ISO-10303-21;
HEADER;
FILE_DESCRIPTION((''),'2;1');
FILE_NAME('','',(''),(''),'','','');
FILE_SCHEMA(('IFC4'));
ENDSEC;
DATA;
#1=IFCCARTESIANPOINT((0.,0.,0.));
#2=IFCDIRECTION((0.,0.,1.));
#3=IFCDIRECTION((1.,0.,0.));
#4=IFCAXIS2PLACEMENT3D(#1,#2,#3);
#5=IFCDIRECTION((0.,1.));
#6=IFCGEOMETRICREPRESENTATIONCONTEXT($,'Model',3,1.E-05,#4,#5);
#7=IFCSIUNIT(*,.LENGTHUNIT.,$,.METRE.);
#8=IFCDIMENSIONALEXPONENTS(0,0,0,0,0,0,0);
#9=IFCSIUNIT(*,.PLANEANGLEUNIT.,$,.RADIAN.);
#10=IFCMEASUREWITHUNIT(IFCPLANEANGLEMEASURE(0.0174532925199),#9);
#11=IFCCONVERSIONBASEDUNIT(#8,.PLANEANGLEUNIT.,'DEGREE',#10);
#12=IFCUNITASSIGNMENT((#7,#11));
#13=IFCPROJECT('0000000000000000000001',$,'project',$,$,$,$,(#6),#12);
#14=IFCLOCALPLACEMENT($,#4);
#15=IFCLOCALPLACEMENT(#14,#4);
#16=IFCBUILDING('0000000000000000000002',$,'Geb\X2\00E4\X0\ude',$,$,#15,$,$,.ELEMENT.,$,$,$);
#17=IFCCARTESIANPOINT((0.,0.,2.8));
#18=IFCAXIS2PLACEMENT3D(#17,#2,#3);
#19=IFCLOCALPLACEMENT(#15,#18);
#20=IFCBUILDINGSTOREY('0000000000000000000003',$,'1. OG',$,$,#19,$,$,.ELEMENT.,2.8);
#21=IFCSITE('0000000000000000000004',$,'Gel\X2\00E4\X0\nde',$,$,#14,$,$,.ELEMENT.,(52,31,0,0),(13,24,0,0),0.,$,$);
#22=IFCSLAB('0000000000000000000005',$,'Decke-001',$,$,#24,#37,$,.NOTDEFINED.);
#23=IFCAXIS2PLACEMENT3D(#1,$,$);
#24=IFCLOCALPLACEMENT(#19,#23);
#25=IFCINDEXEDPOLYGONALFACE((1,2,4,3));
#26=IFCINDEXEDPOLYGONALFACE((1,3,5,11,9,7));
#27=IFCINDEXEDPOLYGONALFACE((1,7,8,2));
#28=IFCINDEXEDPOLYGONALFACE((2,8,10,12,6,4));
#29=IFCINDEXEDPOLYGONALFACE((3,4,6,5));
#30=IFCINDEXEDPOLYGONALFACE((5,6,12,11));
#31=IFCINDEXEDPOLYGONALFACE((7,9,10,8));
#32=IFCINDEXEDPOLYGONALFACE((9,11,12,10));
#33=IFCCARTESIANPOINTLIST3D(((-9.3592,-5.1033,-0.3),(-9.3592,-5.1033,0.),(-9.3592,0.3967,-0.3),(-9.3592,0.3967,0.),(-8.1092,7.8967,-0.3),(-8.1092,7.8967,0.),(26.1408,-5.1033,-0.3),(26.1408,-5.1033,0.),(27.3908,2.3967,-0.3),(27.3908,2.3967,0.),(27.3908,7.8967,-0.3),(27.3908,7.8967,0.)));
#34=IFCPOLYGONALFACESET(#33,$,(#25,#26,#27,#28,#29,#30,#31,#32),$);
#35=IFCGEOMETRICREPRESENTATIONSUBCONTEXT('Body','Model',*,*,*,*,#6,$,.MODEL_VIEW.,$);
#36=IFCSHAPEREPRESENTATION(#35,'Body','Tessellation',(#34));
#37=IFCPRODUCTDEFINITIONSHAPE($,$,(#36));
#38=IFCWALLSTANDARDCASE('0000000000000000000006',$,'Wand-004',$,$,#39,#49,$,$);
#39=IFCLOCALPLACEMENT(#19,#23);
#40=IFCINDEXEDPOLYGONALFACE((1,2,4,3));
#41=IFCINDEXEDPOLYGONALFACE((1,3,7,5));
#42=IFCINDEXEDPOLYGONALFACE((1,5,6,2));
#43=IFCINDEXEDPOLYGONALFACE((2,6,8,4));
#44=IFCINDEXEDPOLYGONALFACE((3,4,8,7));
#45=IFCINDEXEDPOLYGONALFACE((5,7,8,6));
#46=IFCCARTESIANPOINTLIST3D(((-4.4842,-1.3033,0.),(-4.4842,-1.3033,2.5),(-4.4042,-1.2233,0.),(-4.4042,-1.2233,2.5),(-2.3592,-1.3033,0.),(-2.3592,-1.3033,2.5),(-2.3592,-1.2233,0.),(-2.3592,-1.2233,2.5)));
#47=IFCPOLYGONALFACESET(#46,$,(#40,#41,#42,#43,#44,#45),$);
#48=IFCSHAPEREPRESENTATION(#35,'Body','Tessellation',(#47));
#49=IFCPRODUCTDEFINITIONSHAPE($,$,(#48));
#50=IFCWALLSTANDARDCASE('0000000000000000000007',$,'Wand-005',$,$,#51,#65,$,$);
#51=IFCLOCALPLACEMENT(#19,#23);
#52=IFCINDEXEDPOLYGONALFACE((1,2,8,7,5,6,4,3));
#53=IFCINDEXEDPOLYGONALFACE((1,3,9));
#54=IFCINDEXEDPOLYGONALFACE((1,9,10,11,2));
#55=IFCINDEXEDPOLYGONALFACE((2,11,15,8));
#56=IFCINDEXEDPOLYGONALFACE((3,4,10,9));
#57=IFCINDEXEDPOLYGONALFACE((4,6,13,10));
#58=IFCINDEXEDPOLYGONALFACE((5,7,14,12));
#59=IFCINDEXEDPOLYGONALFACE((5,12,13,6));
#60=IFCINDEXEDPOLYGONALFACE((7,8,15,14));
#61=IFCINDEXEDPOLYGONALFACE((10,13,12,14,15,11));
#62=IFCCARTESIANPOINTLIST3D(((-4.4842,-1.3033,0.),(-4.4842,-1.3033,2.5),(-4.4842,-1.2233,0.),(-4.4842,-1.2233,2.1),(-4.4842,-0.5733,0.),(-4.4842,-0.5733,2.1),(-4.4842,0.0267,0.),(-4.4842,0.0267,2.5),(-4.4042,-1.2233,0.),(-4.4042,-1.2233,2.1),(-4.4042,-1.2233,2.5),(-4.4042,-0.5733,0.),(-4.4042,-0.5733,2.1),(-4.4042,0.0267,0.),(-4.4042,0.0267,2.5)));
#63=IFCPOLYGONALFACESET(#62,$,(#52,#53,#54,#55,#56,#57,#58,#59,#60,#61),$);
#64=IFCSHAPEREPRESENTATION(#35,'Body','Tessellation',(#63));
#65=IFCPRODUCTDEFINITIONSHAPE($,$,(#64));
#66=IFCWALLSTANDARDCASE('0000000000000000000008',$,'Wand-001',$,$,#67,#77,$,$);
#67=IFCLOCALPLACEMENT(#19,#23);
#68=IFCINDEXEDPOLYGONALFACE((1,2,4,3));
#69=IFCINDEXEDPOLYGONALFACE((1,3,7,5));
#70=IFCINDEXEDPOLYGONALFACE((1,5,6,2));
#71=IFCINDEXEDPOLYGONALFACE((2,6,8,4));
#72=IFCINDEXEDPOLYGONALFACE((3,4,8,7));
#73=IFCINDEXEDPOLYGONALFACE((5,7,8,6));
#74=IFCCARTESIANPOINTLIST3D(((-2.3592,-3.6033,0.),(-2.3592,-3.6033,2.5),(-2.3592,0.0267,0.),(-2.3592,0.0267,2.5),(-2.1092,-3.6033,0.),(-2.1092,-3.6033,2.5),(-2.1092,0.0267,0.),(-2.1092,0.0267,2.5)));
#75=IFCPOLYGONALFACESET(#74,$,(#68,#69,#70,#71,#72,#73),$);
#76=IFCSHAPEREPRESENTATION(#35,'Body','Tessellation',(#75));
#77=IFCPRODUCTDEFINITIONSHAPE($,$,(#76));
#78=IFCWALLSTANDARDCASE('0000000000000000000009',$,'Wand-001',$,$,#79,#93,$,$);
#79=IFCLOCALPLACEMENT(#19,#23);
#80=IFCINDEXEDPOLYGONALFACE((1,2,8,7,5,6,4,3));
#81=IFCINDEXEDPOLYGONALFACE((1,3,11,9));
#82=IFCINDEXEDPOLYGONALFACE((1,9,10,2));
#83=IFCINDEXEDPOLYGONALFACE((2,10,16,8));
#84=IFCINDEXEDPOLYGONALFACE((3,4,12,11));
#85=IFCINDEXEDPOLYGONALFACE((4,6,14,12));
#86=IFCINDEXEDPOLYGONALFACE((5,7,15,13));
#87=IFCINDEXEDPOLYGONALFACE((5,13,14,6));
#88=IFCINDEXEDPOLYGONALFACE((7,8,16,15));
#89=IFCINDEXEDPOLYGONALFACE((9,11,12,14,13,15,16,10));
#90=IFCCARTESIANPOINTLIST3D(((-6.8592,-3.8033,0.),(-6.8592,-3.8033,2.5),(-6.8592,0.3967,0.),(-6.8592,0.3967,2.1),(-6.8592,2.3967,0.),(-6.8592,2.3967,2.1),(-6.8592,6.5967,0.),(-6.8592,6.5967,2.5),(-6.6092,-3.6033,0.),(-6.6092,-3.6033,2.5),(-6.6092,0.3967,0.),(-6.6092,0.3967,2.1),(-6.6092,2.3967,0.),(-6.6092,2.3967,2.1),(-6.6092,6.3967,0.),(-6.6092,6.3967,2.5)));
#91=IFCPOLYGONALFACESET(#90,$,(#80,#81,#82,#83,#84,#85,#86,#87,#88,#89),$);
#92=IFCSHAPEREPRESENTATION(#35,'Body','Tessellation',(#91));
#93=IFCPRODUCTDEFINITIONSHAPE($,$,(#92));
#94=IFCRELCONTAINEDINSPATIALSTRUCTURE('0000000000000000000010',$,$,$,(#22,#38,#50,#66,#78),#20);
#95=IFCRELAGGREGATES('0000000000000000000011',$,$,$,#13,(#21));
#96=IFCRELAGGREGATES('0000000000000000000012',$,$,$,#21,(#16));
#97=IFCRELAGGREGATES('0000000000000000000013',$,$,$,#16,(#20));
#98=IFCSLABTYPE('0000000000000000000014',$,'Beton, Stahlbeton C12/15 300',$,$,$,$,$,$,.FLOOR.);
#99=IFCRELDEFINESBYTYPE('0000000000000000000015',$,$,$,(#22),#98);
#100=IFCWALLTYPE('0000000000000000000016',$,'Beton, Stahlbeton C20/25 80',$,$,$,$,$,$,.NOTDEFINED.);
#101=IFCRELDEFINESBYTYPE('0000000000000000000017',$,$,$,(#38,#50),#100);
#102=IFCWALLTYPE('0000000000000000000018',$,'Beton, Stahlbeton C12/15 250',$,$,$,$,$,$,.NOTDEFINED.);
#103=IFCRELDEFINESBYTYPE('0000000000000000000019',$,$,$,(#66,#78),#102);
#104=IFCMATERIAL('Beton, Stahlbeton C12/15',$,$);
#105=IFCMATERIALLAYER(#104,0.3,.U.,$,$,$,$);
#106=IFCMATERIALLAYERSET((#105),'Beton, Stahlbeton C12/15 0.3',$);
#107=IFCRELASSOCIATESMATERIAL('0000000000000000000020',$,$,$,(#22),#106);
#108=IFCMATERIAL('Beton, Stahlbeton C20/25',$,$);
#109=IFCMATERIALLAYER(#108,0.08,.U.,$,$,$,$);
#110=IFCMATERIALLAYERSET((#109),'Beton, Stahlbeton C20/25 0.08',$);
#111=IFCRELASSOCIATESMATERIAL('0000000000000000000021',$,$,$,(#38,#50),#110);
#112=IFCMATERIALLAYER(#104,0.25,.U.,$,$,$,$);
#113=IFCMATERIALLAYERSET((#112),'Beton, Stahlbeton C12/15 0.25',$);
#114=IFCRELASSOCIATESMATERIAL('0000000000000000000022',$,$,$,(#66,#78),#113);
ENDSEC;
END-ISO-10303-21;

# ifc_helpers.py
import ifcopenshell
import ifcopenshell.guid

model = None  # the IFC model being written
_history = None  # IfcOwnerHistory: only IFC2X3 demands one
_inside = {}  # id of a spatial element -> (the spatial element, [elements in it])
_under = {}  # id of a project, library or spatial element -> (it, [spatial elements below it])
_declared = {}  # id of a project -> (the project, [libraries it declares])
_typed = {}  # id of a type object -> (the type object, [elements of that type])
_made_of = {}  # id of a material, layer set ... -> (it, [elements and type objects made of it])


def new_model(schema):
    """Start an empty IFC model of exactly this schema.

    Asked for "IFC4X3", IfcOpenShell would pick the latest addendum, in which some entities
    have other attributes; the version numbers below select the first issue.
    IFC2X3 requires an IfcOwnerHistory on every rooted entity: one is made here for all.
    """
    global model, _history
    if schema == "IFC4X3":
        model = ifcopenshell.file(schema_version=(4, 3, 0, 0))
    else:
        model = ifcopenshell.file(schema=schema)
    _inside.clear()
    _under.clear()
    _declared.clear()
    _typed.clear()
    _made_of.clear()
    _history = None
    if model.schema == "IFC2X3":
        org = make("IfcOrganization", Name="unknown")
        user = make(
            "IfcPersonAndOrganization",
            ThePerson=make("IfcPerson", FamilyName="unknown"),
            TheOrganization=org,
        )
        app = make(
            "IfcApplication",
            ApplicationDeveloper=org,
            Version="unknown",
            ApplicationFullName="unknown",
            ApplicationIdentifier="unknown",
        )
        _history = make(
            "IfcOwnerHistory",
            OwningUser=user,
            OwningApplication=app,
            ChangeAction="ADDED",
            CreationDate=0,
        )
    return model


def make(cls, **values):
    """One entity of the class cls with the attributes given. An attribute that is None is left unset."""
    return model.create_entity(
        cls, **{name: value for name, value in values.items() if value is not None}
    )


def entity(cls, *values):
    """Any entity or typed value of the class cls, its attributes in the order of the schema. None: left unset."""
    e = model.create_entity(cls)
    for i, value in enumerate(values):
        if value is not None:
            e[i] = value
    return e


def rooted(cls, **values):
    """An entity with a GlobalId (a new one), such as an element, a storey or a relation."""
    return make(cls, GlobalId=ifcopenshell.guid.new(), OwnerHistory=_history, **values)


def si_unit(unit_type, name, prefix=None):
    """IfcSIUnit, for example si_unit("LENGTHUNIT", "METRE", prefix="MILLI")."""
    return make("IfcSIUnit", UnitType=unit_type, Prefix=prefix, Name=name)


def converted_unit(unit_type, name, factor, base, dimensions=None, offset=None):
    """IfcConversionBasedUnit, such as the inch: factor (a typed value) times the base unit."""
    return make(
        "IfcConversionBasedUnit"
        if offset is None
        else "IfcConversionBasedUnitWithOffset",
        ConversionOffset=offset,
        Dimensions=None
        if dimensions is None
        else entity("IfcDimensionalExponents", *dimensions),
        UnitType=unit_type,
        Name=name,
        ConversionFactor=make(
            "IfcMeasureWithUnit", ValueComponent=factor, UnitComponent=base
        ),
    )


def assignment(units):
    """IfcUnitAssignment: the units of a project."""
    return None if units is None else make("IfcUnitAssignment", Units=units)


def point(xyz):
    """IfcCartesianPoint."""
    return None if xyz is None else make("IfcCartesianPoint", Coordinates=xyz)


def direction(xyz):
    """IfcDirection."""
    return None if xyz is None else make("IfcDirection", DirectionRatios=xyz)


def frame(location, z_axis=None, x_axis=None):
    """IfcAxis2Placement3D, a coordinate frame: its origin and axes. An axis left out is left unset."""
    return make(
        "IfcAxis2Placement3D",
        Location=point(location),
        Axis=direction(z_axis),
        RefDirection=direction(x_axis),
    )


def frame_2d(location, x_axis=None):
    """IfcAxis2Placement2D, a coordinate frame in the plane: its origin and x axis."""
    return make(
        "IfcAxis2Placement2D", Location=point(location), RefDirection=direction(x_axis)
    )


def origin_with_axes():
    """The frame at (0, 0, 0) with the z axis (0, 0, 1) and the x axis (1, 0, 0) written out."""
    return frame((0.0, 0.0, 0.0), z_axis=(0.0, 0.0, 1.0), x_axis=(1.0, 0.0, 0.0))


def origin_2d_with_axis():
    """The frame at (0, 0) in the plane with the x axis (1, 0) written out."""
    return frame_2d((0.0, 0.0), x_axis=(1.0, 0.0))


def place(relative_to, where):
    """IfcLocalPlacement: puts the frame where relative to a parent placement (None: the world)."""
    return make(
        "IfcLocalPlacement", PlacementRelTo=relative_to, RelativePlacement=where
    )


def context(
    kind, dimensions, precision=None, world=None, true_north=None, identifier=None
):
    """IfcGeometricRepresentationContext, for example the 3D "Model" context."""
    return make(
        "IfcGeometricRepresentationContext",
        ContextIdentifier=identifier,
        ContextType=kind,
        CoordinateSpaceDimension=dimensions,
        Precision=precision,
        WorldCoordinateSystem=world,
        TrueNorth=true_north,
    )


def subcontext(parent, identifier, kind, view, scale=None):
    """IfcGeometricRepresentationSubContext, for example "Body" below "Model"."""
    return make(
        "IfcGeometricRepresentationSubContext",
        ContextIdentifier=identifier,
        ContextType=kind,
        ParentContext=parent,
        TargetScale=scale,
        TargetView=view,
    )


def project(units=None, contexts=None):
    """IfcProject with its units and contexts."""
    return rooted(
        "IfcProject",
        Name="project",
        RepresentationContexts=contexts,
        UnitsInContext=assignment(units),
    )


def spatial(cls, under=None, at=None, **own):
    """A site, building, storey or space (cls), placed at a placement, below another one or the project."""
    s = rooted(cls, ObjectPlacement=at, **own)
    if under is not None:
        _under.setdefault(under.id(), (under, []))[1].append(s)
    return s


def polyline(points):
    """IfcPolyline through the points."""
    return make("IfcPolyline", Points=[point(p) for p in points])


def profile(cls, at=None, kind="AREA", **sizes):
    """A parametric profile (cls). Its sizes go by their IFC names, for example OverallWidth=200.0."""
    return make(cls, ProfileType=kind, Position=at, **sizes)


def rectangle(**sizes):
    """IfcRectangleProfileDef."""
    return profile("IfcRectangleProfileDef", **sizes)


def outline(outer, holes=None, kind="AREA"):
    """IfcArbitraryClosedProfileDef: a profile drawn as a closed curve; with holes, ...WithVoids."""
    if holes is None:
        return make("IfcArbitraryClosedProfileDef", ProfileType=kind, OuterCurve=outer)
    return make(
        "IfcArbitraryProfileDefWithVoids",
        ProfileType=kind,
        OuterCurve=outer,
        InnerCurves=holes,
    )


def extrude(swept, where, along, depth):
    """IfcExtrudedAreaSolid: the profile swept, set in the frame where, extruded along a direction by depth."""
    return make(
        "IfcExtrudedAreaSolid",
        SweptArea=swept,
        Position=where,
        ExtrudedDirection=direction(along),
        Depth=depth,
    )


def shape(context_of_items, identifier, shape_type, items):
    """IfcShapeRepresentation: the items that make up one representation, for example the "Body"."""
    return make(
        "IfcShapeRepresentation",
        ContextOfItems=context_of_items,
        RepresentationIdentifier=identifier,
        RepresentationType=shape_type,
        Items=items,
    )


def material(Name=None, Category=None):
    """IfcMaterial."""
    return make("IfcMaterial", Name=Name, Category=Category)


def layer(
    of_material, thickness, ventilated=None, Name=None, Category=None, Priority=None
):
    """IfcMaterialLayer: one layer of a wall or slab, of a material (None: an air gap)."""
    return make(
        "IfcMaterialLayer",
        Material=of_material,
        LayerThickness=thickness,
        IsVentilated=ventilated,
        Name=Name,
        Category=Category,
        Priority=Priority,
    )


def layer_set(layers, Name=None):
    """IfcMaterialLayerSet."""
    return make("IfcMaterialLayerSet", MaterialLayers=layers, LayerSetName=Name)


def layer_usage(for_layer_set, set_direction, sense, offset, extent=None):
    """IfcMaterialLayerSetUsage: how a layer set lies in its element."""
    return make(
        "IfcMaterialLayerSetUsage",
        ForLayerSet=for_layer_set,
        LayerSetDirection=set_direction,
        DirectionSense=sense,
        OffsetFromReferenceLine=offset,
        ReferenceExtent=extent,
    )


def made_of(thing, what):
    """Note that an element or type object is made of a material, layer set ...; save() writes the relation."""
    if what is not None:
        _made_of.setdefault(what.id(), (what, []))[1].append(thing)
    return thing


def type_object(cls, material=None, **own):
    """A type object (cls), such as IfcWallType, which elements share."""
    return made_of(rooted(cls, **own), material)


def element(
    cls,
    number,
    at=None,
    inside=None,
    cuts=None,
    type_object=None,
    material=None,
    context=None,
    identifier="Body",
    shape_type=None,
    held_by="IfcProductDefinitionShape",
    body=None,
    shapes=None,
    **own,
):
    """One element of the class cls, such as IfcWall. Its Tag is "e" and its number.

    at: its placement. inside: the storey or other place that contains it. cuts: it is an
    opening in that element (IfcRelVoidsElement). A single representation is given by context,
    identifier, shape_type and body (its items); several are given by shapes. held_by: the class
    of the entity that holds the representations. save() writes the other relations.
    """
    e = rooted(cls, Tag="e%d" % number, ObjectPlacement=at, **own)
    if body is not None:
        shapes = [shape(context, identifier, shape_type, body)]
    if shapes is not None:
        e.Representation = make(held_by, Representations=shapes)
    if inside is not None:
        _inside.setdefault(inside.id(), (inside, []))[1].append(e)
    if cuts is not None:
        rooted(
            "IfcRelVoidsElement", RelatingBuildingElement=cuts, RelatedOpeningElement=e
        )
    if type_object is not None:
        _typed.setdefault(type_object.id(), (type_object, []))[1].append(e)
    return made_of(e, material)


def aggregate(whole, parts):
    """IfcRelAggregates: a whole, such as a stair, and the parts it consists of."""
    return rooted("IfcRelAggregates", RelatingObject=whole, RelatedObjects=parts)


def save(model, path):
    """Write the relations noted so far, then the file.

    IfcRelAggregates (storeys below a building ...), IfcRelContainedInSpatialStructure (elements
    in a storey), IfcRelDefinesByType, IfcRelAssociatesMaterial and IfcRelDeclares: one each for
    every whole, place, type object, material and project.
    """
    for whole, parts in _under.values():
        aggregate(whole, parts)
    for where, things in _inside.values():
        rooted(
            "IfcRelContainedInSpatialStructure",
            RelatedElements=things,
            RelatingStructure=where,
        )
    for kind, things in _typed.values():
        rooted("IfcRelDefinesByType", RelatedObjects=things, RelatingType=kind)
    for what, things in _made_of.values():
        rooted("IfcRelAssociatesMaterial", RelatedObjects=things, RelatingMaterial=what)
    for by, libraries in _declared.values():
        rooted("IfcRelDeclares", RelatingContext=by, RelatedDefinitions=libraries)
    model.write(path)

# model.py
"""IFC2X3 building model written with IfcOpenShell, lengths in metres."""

from ifc_helpers import new_model, entity, si_unit, converted_unit, direction, frame, origin_with_axes, origin_2d_with_axis, place, context, subcontext, project, spatial, polyline, rectangle, outline, extrude, material, layer, layer_set, layer_usage, type_object, element, save


model = new_model("IFC2X3")

# Units and contexts
model_context = context("Model", 3, precision=1e-05, world=origin_with_axes(), true_north=direction((0.0, 1.0)))
body_context = subcontext(model_context, "Body", "Model", "MODEL_VIEW")
ifc_project = project(units=[si_unit("LENGTHUNIT", "METRE"), converted_unit("PLANEANGLEUNIT", "DEGREE", entity("IfcPlaneAngleMeasure", 0.0174532925199), si_unit("PLANEANGLEUNIT", "RADIAN"), dimensions=[0, 0, 0, 0, 0, 0, 0])], contexts=[model_context])

# Site, building, storey
site_placement = place(None, origin_with_axes())
site = spatial("IfcSite", under=ifc_project, at=site_placement, Name="Gelände", CompositionType="ELEMENT", RefLatitude=(52, 31, 0, 0), RefLongitude=(13, 24, 0, 0), RefElevation=0.0)
building_placement = place(site_placement, origin_with_axes())
building = spatial("IfcBuilding", under=site, at=building_placement, Name="Gebäude", CompositionType="ELEMENT")
storey_placement = place(building_placement, frame((0.0, 0.0, 2.8), z_axis=(0.0, 0.0, 1.0), x_axis=(1.0, 0.0, 0.0)))
storey = spatial("IfcBuildingStorey", under=building, at=storey_placement, Name="1. OG", CompositionType="ELEMENT", Elevation=2.8)

# Slab
ifc_material_1 = material(Name="Beton, Stahlbeton C12/15")
ifc_layer_1 = layer(ifc_material_1, 0.3, ventilated="UNKNOWN")
ifc_layer_set_1 = layer_set([ifc_layer_1], Name="Beton, Stahlbeton C12/15 0.3")
ifc_layer_usage_1 = layer_usage(ifc_layer_set_1, "AXIS3", "NEGATIVE", 0.3)
slab_type = type_object("IfcSlabType", Name="Beton, Stahlbeton C12/15 300", PredefinedType="FLOOR")
slab_placement = place(storey_placement, frame((-9.3592, -5.1033, 0.0), z_axis=(0.0, 0.0, 1.0), x_axis=(1.0, 0.0, 0.0)))
element("IfcSlab", 1, at=slab_placement, inside=storey, type_object=slab_type, material=ifc_layer_usage_1, Name="Decke-001", PredefinedType="NOTDEFINED", context=body_context, shape_type="SweptSolid", body=[
    extrude(outline(polyline([(0.0, 0.0), (35.5, 0.0), (36.75, 7.5), (36.75, 13.0), (1.25, 13.0), (0.0, 5.5), (0.0, 0.0)])), frame((0.0, 0.0, -0.3), z_axis=(0.0, 0.0, 1.0), x_axis=(1.0, 0.0, 0.0)), (0.0, 0.0, 1.0), 0.3),
])

# Wall
ifc_material_2 = material(Name="Beton, Stahlbeton C20/25")
ifc_layer_2 = layer(ifc_material_2, 0.08, ventilated="UNKNOWN")
ifc_layer_set_2 = layer_set([ifc_layer_2], Name="Beton, Stahlbeton C20/25 0.08")
ifc_layer_usage_2 = layer_usage(ifc_layer_set_2, "AXIS2", "NEGATIVE", 0.0)
wall_type_1 = type_object("IfcWallType", Name="Beton, Stahlbeton C20/25 80", PredefinedType="NOTDEFINED")
wall_1_placement = place(storey_placement, frame((-2.3592, -1.3033, 0.0), z_axis=(0.0, 0.0, 1.0), x_axis=(-1.0, 0.0, 0.0)))
element("IfcWallStandardCase", 2, at=wall_1_placement, inside=storey, type_object=wall_type_1, material=ifc_layer_usage_2, Name="Wand-004", context=body_context, shape_type="SweptSolid", body=[
    extrude(outline(polyline([(0.0, -0.08), (2.045, -0.08), (2.125, 0.0), (0.0, 0.0), (0.0, -0.08)])), origin_with_axes(), (0.0, 0.0, 1.0), 2.5),
])

# Wall, opening
ifc_layer_usage_3 = layer_usage(ifc_layer_set_2, "AXIS2", "NEGATIVE", 0.0)
wall_2_placement = place(storey_placement, frame((-4.4842, -1.3033, 0.0), z_axis=(0.0, 0.0, 1.0), x_axis=(0.0, 1.0, 0.0)))
wall_2 = element("IfcWallStandardCase", 3, at=wall_2_placement, inside=storey, type_object=wall_type_1, material=ifc_layer_usage_3, Name="Wand-005", context=body_context, shape_type="SweptSolid", body=[
    extrude(outline(polyline([(0.08, -0.08), (1.33, -0.08), (1.33, 0.0), (0.0, 0.0), (0.08, -0.08)])), origin_with_axes(), (0.0, 0.0, 1.0), 2.5),
])
opening_1_placement = place(wall_2_placement, frame((0.405, 0.0, 0.0), z_axis=(0.0, 0.0, 1.0), x_axis=(1.0, 0.0, 0.0)))
element("IfcOpeningElement", 4, at=opening_1_placement, cuts=wall_2, context=body_context, shape_type="SweptSolid", body=[
    extrude(rectangle(XDim=0.65, YDim=2.1, at=origin_2d_with_axis()), frame((0.0, 0.08, 1.05), z_axis=(0.0, 1.0, 0.0), x_axis=(-1.0, 0.0, 0.0)), (0.0, 0.0, -1.0), 0.24),
])

# Wall
ifc_layer_3 = layer(ifc_material_1, 0.25, ventilated="UNKNOWN")
ifc_layer_set_3 = layer_set([ifc_layer_3], Name="Beton, Stahlbeton C12/15 0.25")
ifc_layer_usage_4 = layer_usage(ifc_layer_set_3, "AXIS2", "POSITIVE", 0.0)
wall_type_2 = type_object("IfcWallType", Name="Beton, Stahlbeton C12/15 250", PredefinedType="NOTDEFINED")
wall_3_placement = place(storey_placement, frame((-2.1092, -3.6033, 0.0), z_axis=(0.0, 0.0, 1.0), x_axis=(0.0, 1.0, 0.0)))
element("IfcWallStandardCase", 5, at=wall_3_placement, inside=storey, type_object=wall_type_2, material=ifc_layer_usage_4, Name="Wand-001", context=body_context, shape_type="SweptSolid", body=[
    extrude(outline(polyline([(0.0, 0.0), (3.63, 0.0), (3.63, 0.25), (0.0, 0.25), (0.0, 0.0)])), origin_with_axes(), (0.0, 0.0, 1.0), 2.5),
])

# Wall, opening
ifc_layer_usage_5 = layer_usage(ifc_layer_set_3, "AXIS2", "POSITIVE", 0.0)
wall_4_placement = place(storey_placement, frame((-6.6092, -3.6033, 0.0), z_axis=(0.0, 0.0, 1.0), x_axis=(0.0, 1.0, 0.0)))
wall_4 = element("IfcWallStandardCase", 6, at=wall_4_placement, inside=storey, type_object=wall_type_2, material=ifc_layer_usage_5, Name="Wand-001", context=body_context, shape_type="SweptSolid", body=[
    extrude(outline(polyline([(0.0, 0.0), (10.0, 0.0), (10.2, 0.25), (-0.2, 0.25), (0.0, 0.0)])), origin_with_axes(), (0.0, 0.0, 1.0), 2.5),
])
opening_2_placement = place(wall_4_placement, frame((5.0, 0.0, 0.0), z_axis=(0.0, 0.0, 1.0), x_axis=(1.0, 0.0, 0.0)))
element("IfcOpeningElement", 7, at=opening_2_placement, cuts=wall_4, context=body_context, shape_type="SweptSolid", body=[
    extrude(rectangle(XDim=2.0, YDim=2.1, at=origin_2d_with_axis()), frame((0.0, 0.5, 1.05), z_axis=(0.0, 1.0, 0.0), x_axis=(-1.0, 0.0, 0.0)), (0.0, 0.0, -1.0), 0.75),
])

save(model, "model.ifc")
